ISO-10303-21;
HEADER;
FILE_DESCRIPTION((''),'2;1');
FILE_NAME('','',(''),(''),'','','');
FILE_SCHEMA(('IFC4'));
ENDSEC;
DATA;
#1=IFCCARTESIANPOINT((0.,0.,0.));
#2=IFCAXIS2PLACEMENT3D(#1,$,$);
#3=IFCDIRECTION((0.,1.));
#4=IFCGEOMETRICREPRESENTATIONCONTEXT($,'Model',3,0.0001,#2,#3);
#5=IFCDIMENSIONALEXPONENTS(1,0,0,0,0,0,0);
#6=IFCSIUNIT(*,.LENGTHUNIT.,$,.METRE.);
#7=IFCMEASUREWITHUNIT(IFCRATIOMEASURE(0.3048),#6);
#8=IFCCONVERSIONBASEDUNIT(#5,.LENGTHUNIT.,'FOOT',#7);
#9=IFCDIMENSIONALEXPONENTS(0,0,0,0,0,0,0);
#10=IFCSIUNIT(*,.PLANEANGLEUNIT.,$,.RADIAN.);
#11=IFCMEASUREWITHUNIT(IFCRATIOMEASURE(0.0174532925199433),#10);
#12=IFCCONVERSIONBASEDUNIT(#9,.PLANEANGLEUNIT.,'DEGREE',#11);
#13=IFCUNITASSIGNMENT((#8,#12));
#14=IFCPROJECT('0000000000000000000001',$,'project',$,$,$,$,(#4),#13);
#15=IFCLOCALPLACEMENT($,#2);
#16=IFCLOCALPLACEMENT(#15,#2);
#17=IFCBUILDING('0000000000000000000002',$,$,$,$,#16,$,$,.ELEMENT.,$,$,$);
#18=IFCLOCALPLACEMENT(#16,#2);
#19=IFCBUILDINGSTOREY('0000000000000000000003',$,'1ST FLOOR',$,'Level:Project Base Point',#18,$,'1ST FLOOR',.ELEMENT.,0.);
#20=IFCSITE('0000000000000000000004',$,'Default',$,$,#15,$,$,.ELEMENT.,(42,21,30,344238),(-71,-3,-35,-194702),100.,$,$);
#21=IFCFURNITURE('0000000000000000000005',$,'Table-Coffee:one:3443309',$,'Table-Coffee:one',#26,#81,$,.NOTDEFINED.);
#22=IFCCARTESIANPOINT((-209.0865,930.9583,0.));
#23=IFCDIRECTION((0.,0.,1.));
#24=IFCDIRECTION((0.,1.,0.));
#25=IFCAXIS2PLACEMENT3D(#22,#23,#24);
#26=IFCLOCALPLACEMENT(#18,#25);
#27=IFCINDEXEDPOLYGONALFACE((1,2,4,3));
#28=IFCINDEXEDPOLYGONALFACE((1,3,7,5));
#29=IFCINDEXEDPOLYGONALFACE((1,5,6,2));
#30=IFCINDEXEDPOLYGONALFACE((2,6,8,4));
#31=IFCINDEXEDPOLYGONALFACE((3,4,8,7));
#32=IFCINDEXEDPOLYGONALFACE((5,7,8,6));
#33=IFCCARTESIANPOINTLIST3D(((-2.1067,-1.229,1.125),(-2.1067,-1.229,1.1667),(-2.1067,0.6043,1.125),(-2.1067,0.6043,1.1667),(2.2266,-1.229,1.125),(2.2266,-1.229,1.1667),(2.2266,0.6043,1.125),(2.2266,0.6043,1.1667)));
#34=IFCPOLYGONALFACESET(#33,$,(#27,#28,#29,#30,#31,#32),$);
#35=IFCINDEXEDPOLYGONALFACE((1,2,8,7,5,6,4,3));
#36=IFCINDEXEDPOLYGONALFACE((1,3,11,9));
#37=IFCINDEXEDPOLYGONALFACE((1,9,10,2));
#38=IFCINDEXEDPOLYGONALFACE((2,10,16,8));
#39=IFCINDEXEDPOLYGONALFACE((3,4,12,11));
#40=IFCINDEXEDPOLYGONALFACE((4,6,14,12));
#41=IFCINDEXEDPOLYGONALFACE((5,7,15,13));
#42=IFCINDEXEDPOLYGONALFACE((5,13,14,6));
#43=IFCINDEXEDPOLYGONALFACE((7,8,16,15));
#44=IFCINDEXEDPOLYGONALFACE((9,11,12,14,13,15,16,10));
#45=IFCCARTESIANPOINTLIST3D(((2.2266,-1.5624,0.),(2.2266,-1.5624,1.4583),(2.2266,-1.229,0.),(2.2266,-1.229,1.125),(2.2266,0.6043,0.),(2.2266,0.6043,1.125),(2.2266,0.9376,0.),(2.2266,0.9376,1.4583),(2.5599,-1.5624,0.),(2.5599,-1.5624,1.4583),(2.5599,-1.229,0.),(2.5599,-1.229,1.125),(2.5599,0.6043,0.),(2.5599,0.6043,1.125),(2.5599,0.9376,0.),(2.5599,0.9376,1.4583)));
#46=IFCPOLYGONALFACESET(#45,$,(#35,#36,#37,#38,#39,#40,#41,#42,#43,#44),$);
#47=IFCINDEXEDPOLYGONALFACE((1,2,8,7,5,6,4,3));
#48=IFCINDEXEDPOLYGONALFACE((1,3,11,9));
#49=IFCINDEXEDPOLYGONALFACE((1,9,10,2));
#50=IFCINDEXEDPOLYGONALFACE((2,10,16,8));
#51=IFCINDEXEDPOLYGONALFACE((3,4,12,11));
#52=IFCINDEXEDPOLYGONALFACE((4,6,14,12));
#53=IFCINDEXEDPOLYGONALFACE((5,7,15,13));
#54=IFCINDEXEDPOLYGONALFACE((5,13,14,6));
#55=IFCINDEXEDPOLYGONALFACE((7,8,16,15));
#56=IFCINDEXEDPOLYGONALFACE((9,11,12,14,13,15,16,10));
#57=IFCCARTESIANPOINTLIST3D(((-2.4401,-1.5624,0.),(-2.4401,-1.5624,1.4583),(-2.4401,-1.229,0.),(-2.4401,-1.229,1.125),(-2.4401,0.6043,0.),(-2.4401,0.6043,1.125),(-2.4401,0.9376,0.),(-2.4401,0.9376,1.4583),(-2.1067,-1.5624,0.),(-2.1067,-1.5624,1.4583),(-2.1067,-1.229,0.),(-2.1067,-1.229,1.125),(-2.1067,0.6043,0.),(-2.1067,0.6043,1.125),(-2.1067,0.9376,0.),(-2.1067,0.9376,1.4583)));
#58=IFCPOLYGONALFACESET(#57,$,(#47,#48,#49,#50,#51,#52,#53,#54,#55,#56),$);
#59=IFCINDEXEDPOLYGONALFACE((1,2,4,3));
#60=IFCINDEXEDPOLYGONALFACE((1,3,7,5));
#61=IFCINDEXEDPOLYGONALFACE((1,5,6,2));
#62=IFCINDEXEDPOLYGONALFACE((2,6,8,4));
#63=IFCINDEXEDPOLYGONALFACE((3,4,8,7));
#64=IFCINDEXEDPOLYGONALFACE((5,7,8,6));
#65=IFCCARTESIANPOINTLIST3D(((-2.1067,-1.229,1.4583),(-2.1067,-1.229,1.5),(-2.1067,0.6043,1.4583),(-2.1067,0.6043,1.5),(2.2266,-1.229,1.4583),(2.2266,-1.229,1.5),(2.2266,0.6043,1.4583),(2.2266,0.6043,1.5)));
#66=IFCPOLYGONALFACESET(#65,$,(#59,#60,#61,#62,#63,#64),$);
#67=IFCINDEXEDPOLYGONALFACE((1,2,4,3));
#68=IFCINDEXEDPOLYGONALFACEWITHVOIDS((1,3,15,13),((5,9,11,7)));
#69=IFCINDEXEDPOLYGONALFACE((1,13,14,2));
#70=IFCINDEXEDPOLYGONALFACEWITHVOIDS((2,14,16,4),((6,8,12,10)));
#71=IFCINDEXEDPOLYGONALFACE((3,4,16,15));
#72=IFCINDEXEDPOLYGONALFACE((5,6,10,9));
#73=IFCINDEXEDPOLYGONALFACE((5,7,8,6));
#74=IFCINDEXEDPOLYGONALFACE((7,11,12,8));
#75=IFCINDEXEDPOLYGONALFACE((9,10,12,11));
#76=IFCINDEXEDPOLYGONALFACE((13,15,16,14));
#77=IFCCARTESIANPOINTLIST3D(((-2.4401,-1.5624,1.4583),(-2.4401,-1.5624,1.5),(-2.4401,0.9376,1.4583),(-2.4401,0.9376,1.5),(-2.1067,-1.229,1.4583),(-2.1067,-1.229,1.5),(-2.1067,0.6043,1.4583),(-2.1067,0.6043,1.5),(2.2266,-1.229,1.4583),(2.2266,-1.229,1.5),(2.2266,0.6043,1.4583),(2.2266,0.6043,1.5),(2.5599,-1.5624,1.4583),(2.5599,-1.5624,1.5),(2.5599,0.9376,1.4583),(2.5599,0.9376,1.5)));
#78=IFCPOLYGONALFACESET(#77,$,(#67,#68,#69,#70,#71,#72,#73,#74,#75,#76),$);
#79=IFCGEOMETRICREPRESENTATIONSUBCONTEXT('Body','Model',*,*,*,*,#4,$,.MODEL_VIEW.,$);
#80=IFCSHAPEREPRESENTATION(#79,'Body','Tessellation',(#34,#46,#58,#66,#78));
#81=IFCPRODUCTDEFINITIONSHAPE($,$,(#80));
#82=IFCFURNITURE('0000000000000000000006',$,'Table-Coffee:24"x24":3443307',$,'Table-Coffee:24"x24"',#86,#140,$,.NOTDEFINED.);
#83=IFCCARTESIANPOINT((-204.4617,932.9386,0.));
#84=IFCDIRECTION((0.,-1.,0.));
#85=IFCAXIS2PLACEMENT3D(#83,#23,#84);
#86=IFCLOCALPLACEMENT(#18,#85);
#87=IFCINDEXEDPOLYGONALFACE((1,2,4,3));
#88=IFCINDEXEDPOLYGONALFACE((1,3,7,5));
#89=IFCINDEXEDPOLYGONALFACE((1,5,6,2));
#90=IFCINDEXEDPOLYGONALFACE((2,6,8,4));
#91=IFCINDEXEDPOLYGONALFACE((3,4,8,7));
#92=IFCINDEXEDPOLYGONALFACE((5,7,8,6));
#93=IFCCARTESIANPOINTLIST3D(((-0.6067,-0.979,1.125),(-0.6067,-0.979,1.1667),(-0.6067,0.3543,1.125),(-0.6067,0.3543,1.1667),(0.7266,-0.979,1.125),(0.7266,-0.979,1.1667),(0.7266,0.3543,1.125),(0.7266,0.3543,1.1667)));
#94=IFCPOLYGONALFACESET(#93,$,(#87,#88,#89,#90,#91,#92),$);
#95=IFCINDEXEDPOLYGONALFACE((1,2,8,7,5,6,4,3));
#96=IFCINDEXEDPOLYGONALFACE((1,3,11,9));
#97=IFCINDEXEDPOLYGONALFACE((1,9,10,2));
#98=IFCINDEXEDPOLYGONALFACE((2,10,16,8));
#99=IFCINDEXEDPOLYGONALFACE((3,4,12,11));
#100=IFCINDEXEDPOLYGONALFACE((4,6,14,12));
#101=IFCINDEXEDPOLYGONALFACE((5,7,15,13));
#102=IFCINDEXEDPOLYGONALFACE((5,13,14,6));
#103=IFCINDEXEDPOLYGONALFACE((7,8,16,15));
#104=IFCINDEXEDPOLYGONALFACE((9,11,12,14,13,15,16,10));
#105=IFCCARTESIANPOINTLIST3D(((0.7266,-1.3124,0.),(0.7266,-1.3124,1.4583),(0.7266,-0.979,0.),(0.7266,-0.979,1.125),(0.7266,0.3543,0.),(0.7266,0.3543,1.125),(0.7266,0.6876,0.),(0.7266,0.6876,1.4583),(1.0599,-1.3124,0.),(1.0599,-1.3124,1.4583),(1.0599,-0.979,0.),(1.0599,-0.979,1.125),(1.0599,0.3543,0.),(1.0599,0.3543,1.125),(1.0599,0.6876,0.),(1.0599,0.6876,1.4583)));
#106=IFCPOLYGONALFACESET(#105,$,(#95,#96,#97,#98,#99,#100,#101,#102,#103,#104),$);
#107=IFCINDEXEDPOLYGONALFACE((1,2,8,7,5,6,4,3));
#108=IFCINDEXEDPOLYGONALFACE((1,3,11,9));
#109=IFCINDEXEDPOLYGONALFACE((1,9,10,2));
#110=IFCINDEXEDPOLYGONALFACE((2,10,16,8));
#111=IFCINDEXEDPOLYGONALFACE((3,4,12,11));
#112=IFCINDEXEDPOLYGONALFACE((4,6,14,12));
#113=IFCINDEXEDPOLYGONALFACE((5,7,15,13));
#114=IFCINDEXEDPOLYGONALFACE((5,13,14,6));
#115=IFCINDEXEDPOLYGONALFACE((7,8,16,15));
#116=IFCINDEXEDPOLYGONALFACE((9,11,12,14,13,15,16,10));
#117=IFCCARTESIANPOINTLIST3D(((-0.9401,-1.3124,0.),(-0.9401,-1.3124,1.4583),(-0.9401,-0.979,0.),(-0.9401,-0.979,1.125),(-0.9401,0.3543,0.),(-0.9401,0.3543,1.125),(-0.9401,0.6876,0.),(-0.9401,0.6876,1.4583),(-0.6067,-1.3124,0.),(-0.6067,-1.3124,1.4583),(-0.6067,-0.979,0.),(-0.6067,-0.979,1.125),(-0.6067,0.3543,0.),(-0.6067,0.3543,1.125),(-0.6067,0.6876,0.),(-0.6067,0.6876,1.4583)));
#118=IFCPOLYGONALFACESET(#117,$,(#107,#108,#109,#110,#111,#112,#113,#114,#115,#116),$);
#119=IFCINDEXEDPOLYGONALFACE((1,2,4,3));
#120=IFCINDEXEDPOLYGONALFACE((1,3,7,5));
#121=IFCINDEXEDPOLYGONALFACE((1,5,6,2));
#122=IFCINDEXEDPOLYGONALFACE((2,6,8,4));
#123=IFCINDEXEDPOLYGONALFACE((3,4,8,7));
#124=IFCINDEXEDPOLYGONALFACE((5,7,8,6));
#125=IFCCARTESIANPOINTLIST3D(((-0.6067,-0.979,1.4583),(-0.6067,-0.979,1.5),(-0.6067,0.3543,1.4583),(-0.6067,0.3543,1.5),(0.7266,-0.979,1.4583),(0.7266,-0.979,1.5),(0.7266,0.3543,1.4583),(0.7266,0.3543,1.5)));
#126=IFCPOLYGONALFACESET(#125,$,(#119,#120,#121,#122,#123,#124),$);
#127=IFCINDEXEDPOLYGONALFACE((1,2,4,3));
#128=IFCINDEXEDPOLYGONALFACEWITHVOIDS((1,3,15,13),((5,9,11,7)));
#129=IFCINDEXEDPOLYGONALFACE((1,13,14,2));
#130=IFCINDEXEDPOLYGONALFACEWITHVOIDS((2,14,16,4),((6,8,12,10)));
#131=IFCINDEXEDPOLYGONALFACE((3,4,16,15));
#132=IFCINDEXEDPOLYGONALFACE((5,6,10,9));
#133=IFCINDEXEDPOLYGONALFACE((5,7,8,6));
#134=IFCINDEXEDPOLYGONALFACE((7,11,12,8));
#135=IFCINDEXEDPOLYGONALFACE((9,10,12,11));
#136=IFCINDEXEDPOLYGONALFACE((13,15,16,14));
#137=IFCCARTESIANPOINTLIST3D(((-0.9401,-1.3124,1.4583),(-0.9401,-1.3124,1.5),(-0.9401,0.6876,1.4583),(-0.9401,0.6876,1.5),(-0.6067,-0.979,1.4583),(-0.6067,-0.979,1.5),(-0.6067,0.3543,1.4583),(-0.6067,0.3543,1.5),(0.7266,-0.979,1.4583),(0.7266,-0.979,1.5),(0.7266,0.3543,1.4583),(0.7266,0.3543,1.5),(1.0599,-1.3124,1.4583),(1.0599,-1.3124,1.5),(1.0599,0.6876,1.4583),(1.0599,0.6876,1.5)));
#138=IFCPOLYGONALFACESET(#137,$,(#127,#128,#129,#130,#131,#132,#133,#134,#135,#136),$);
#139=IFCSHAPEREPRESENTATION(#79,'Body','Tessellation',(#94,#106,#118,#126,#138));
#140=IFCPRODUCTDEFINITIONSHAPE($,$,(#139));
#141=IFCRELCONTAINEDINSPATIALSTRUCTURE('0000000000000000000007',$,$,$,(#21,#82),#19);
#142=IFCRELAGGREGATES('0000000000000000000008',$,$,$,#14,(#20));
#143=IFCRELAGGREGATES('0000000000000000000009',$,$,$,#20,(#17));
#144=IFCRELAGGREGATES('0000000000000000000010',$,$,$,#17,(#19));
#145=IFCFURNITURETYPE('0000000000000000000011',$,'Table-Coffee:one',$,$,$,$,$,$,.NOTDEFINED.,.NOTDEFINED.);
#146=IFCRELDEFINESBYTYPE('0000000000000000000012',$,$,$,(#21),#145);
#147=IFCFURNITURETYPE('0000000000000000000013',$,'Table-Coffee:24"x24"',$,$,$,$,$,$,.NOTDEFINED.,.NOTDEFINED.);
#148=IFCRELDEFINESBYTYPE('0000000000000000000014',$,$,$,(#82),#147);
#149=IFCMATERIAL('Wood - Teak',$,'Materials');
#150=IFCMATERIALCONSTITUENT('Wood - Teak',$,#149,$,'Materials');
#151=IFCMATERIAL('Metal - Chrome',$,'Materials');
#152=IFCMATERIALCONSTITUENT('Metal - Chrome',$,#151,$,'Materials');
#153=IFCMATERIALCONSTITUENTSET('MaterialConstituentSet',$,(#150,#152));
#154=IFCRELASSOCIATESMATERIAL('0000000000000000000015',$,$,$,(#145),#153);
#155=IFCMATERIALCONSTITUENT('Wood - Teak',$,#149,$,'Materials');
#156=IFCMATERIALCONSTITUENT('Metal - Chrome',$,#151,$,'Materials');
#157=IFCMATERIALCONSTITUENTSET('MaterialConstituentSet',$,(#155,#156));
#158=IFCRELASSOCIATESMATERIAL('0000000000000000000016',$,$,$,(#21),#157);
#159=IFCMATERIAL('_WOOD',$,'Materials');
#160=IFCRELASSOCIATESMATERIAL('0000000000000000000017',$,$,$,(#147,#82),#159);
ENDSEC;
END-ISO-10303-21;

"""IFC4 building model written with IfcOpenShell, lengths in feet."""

from ifc_helpers import new_model, entity, si_unit, converted_unit, direction, frame, origin, origin_2d_with_axis, place, context, subcontext, project, spatial, polyline, rectangle, outline, extrude, source, transform, mapped, material, constituent, constituent_set, type_object, type_shapes, element, save


model = new_model("IFC4")

# Units and contexts
model_context = context("Model", 3, precision=0.0001, world=origin(), true_north=direction((0.0, 1.0)))
body_context = subcontext(model_context, "Body", "Model", "MODEL_VIEW")
ifc_project = project(units=[converted_unit("LENGTHUNIT", "FOOT", entity("IfcRatioMeasure", 0.3048), si_unit("LENGTHUNIT", "METRE"), dimensions=[1, 0, 0, 0, 0, 0, 0]), converted_unit("PLANEANGLEUNIT", "DEGREE", entity("IfcRatioMeasure", 0.0174532925199433), si_unit("PLANEANGLEUNIT", "RADIAN"), dimensions=[0, 0, 0, 0, 0, 0, 0])], contexts=[model_context])

# Site, building, storey
site_placement = place(None, origin())
site = spatial("IfcSite", under=ifc_project, at=site_placement, Name="Default", CompositionType="ELEMENT", RefLatitude=(42, 21, 30, 344238), RefLongitude=(-71, -3, -35, -194702), RefElevation=100.0)
building_placement = place(site_placement, origin())
building = spatial("IfcBuilding", under=site, at=building_placement, CompositionType="ELEMENT")
storey_placement = place(building_placement, origin())
storey = spatial("IfcBuildingStorey", under=building, at=storey_placement, Name="1ST FLOOR", ObjectType="Level:Project Base Point", LongName="1ST FLOOR", CompositionType="ELEMENT", Elevation=0.0)

# Furniture
ifc_material_1 = material(Name="Metal - Chrome", Category="Materials")
ifc_material_2 = material(Name="Wood - Teak", Category="Materials")
ifc_constituent_1 = constituent(ifc_material_2, Name="Wood - Teak", Category="Materials")
ifc_constituent_2 = constituent(ifc_material_1, Name="Metal - Chrome", Category="Materials")
ifc_constituent_set_1 = constituent_set(constituents=[ifc_constituent_1, ifc_constituent_2], Name="MaterialConstituentSet")
ifc_constituent_3 = constituent(ifc_material_2, Name="Wood - Teak", Category="Materials")
ifc_constituent_4 = constituent(ifc_material_1, Name="Metal - Chrome", Category="Materials")
ifc_constituent_set_2 = constituent_set(constituents=[ifc_constituent_3, ifc_constituent_4], Name="MaterialConstituentSet")
furniture_type_1 = type_object("IfcFurnitureType", Name="Table-Coffee:one", AssemblyPlace="NOTDEFINED", PredefinedType="NOTDEFINED", material=ifc_constituent_set_2)
shared_shape_1 = source(origin(), body_context, "Body", "SweptSolid", [
    extrude(rectangle(XDim=1.8333, YDim=4.3333, at=origin_2d_with_axis()), frame((0.0599, -0.3124, 1.125), z_axis=(0.0, 0.0, 1.0), x_axis=(0.0, 1.0, 0.0)), (0.0, 0.0, 1.0), 0.0417),
    extrude(outline(polyline([(-1.25, -0.6458), (-0.9167, -0.6458), (-0.9167, 0.4792), (0.9167, 0.4792), (0.9167, -0.6458), (1.25, -0.6458), (1.25, 0.8125), (-1.25, 0.8125), (-1.25, -0.6458)])), frame((2.2266, -0.3124, 0.6458), z_axis=(1.0, 0.0, 0.0), x_axis=(0.0, 1.0, 0.0)), (0.0, 0.0, 1.0), 0.3333),
    extrude(outline(polyline([(-0.8125, -1.25), (0.6458, -1.25), (0.6458, -0.9167), (-0.4792, -0.9167), (-0.4792, 0.9167), (0.6458, 0.9167), (0.6458, 1.25), (-0.8125, 1.25), (-0.8125, -1.25)])), frame((-2.4401, -0.3124, 0.6458), z_axis=(1.0, 0.0, 0.0), x_axis=(0.0, 0.0, -1.0)), (0.0, 0.0, 1.0), 0.3333),
    extrude(rectangle(XDim=1.8333, YDim=4.3333, at=origin_2d_with_axis()), frame((0.0599, -0.3124, 1.4583), z_axis=(0.0, 0.0, 1.0), x_axis=(0.0, 1.0, 0.0)), (0.0, 0.0, 1.0), 0.0417),
    extrude(outline(polyline([(-1.25, -2.5), (1.25, -2.5), (1.25, 2.5), (-1.25, 2.5), (-1.25, -2.5)]), holes=[polyline([(-0.9167, -2.1667), (-0.9167, 2.1667), (0.9167, 2.1667), (0.9167, -2.1667), (-0.9167, -2.1667)])]), frame((0.0599, -0.3124, 1.4583), z_axis=(0.0, 0.0, 1.0), x_axis=(0.0, 1.0, 0.0)), (0.0, 0.0, 1.0), 0.0417),
])
type_shapes(furniture_type_1, [shared_shape_1])
furniture_1_placement = place(storey_placement, frame((-209.0865, 930.9583, 0.0), z_axis=(0.0, 0.0, 1.0), x_axis=(0.0, 1.0, 0.0)))
element("IfcFurniture", 1, at=furniture_1_placement, inside=storey, type_object=furniture_type_1, material=ifc_constituent_set_1, Name="Table-Coffee:one:3443309", ObjectType="Table-Coffee:one", PredefinedType="NOTDEFINED", context=body_context, shape_type="MappedRepresentation", body=[
    mapped(shared_shape_1, transform((0.0, 0.0, 0.0), scale=1.0)),
])
ifc_material_3 = material(Name="_WOOD", Category="Materials")
furniture_type_2 = type_object("IfcFurnitureType", Name="Table-Coffee:24\"x24\"", AssemblyPlace="NOTDEFINED", PredefinedType="NOTDEFINED", material=ifc_material_3)
shared_shape_2 = source(origin(), body_context, "Body", "SweptSolid", [
    extrude(rectangle(XDim=1.3333, YDim=1.3333, at=origin_2d_with_axis()), frame((0.0599, -0.3124, 1.125), z_axis=(0.0, 0.0, 1.0), x_axis=(0.0, 1.0, 0.0)), (0.0, 0.0, 1.0), 0.0417),
    extrude(outline(polyline([(-1.0, -0.6458), (-0.6667, -0.6458), (-0.6667, 0.4792), (0.6667, 0.4792), (0.6667, -0.6458), (1.0, -0.6458), (1.0, 0.8125), (-1.0, 0.8125), (-1.0, -0.6458)])), frame((0.7266, -0.3124, 0.6458), z_axis=(1.0, 0.0, 0.0), x_axis=(0.0, 1.0, 0.0)), (0.0, 0.0, 1.0), 0.3333),
    extrude(outline(polyline([(-0.8125, -1.0), (0.6458, -1.0), (0.6458, -0.6667), (-0.4792, -0.6667), (-0.4792, 0.6667), (0.6458, 0.6667), (0.6458, 1.0), (-0.8125, 1.0), (-0.8125, -1.0)])), frame((-0.9401, -0.3124, 0.6458), z_axis=(1.0, 0.0, 0.0), x_axis=(0.0, 0.0, -1.0)), (0.0, 0.0, 1.0), 0.3333),
    extrude(rectangle(XDim=1.3333, YDim=1.3333, at=origin_2d_with_axis()), frame((0.0599, -0.3124, 1.4583), z_axis=(0.0, 0.0, 1.0), x_axis=(0.0, 1.0, 0.0)), (0.0, 0.0, 1.0), 0.0417),
    extrude(outline(polyline([(-1.0, -1.0), (1.0, -1.0), (1.0, 1.0), (-1.0, 1.0), (-1.0, -1.0)]), holes=[polyline([(-0.6667, -0.6667), (-0.6667, 0.6667), (0.6667, 0.6667), (0.6667, -0.6667), (-0.6667, -0.6667)])]), frame((0.0599, -0.3124, 1.4583), z_axis=(0.0, 0.0, 1.0), x_axis=(0.0, 1.0, 0.0)), (0.0, 0.0, 1.0), 0.0417),
])
type_shapes(furniture_type_2, [shared_shape_2])
furniture_2_placement = place(storey_placement, frame((-204.4617, 932.9386, 0.0), z_axis=(0.0, 0.0, 1.0), x_axis=(0.0, -1.0, 0.0)))
element("IfcFurniture", 2, at=furniture_2_placement, inside=storey, type_object=furniture_type_2, material=ifc_material_3, Name="Table-Coffee:24\"x24\":3443307", ObjectType="Table-Coffee:24\"x24\"", PredefinedType="NOTDEFINED", context=body_context, shape_type="MappedRepresentation", body=[
    mapped(shared_shape_2, transform((0.0, 0.0, 0.0), scale=1.0)),
])

save(model, "model.ifc")
